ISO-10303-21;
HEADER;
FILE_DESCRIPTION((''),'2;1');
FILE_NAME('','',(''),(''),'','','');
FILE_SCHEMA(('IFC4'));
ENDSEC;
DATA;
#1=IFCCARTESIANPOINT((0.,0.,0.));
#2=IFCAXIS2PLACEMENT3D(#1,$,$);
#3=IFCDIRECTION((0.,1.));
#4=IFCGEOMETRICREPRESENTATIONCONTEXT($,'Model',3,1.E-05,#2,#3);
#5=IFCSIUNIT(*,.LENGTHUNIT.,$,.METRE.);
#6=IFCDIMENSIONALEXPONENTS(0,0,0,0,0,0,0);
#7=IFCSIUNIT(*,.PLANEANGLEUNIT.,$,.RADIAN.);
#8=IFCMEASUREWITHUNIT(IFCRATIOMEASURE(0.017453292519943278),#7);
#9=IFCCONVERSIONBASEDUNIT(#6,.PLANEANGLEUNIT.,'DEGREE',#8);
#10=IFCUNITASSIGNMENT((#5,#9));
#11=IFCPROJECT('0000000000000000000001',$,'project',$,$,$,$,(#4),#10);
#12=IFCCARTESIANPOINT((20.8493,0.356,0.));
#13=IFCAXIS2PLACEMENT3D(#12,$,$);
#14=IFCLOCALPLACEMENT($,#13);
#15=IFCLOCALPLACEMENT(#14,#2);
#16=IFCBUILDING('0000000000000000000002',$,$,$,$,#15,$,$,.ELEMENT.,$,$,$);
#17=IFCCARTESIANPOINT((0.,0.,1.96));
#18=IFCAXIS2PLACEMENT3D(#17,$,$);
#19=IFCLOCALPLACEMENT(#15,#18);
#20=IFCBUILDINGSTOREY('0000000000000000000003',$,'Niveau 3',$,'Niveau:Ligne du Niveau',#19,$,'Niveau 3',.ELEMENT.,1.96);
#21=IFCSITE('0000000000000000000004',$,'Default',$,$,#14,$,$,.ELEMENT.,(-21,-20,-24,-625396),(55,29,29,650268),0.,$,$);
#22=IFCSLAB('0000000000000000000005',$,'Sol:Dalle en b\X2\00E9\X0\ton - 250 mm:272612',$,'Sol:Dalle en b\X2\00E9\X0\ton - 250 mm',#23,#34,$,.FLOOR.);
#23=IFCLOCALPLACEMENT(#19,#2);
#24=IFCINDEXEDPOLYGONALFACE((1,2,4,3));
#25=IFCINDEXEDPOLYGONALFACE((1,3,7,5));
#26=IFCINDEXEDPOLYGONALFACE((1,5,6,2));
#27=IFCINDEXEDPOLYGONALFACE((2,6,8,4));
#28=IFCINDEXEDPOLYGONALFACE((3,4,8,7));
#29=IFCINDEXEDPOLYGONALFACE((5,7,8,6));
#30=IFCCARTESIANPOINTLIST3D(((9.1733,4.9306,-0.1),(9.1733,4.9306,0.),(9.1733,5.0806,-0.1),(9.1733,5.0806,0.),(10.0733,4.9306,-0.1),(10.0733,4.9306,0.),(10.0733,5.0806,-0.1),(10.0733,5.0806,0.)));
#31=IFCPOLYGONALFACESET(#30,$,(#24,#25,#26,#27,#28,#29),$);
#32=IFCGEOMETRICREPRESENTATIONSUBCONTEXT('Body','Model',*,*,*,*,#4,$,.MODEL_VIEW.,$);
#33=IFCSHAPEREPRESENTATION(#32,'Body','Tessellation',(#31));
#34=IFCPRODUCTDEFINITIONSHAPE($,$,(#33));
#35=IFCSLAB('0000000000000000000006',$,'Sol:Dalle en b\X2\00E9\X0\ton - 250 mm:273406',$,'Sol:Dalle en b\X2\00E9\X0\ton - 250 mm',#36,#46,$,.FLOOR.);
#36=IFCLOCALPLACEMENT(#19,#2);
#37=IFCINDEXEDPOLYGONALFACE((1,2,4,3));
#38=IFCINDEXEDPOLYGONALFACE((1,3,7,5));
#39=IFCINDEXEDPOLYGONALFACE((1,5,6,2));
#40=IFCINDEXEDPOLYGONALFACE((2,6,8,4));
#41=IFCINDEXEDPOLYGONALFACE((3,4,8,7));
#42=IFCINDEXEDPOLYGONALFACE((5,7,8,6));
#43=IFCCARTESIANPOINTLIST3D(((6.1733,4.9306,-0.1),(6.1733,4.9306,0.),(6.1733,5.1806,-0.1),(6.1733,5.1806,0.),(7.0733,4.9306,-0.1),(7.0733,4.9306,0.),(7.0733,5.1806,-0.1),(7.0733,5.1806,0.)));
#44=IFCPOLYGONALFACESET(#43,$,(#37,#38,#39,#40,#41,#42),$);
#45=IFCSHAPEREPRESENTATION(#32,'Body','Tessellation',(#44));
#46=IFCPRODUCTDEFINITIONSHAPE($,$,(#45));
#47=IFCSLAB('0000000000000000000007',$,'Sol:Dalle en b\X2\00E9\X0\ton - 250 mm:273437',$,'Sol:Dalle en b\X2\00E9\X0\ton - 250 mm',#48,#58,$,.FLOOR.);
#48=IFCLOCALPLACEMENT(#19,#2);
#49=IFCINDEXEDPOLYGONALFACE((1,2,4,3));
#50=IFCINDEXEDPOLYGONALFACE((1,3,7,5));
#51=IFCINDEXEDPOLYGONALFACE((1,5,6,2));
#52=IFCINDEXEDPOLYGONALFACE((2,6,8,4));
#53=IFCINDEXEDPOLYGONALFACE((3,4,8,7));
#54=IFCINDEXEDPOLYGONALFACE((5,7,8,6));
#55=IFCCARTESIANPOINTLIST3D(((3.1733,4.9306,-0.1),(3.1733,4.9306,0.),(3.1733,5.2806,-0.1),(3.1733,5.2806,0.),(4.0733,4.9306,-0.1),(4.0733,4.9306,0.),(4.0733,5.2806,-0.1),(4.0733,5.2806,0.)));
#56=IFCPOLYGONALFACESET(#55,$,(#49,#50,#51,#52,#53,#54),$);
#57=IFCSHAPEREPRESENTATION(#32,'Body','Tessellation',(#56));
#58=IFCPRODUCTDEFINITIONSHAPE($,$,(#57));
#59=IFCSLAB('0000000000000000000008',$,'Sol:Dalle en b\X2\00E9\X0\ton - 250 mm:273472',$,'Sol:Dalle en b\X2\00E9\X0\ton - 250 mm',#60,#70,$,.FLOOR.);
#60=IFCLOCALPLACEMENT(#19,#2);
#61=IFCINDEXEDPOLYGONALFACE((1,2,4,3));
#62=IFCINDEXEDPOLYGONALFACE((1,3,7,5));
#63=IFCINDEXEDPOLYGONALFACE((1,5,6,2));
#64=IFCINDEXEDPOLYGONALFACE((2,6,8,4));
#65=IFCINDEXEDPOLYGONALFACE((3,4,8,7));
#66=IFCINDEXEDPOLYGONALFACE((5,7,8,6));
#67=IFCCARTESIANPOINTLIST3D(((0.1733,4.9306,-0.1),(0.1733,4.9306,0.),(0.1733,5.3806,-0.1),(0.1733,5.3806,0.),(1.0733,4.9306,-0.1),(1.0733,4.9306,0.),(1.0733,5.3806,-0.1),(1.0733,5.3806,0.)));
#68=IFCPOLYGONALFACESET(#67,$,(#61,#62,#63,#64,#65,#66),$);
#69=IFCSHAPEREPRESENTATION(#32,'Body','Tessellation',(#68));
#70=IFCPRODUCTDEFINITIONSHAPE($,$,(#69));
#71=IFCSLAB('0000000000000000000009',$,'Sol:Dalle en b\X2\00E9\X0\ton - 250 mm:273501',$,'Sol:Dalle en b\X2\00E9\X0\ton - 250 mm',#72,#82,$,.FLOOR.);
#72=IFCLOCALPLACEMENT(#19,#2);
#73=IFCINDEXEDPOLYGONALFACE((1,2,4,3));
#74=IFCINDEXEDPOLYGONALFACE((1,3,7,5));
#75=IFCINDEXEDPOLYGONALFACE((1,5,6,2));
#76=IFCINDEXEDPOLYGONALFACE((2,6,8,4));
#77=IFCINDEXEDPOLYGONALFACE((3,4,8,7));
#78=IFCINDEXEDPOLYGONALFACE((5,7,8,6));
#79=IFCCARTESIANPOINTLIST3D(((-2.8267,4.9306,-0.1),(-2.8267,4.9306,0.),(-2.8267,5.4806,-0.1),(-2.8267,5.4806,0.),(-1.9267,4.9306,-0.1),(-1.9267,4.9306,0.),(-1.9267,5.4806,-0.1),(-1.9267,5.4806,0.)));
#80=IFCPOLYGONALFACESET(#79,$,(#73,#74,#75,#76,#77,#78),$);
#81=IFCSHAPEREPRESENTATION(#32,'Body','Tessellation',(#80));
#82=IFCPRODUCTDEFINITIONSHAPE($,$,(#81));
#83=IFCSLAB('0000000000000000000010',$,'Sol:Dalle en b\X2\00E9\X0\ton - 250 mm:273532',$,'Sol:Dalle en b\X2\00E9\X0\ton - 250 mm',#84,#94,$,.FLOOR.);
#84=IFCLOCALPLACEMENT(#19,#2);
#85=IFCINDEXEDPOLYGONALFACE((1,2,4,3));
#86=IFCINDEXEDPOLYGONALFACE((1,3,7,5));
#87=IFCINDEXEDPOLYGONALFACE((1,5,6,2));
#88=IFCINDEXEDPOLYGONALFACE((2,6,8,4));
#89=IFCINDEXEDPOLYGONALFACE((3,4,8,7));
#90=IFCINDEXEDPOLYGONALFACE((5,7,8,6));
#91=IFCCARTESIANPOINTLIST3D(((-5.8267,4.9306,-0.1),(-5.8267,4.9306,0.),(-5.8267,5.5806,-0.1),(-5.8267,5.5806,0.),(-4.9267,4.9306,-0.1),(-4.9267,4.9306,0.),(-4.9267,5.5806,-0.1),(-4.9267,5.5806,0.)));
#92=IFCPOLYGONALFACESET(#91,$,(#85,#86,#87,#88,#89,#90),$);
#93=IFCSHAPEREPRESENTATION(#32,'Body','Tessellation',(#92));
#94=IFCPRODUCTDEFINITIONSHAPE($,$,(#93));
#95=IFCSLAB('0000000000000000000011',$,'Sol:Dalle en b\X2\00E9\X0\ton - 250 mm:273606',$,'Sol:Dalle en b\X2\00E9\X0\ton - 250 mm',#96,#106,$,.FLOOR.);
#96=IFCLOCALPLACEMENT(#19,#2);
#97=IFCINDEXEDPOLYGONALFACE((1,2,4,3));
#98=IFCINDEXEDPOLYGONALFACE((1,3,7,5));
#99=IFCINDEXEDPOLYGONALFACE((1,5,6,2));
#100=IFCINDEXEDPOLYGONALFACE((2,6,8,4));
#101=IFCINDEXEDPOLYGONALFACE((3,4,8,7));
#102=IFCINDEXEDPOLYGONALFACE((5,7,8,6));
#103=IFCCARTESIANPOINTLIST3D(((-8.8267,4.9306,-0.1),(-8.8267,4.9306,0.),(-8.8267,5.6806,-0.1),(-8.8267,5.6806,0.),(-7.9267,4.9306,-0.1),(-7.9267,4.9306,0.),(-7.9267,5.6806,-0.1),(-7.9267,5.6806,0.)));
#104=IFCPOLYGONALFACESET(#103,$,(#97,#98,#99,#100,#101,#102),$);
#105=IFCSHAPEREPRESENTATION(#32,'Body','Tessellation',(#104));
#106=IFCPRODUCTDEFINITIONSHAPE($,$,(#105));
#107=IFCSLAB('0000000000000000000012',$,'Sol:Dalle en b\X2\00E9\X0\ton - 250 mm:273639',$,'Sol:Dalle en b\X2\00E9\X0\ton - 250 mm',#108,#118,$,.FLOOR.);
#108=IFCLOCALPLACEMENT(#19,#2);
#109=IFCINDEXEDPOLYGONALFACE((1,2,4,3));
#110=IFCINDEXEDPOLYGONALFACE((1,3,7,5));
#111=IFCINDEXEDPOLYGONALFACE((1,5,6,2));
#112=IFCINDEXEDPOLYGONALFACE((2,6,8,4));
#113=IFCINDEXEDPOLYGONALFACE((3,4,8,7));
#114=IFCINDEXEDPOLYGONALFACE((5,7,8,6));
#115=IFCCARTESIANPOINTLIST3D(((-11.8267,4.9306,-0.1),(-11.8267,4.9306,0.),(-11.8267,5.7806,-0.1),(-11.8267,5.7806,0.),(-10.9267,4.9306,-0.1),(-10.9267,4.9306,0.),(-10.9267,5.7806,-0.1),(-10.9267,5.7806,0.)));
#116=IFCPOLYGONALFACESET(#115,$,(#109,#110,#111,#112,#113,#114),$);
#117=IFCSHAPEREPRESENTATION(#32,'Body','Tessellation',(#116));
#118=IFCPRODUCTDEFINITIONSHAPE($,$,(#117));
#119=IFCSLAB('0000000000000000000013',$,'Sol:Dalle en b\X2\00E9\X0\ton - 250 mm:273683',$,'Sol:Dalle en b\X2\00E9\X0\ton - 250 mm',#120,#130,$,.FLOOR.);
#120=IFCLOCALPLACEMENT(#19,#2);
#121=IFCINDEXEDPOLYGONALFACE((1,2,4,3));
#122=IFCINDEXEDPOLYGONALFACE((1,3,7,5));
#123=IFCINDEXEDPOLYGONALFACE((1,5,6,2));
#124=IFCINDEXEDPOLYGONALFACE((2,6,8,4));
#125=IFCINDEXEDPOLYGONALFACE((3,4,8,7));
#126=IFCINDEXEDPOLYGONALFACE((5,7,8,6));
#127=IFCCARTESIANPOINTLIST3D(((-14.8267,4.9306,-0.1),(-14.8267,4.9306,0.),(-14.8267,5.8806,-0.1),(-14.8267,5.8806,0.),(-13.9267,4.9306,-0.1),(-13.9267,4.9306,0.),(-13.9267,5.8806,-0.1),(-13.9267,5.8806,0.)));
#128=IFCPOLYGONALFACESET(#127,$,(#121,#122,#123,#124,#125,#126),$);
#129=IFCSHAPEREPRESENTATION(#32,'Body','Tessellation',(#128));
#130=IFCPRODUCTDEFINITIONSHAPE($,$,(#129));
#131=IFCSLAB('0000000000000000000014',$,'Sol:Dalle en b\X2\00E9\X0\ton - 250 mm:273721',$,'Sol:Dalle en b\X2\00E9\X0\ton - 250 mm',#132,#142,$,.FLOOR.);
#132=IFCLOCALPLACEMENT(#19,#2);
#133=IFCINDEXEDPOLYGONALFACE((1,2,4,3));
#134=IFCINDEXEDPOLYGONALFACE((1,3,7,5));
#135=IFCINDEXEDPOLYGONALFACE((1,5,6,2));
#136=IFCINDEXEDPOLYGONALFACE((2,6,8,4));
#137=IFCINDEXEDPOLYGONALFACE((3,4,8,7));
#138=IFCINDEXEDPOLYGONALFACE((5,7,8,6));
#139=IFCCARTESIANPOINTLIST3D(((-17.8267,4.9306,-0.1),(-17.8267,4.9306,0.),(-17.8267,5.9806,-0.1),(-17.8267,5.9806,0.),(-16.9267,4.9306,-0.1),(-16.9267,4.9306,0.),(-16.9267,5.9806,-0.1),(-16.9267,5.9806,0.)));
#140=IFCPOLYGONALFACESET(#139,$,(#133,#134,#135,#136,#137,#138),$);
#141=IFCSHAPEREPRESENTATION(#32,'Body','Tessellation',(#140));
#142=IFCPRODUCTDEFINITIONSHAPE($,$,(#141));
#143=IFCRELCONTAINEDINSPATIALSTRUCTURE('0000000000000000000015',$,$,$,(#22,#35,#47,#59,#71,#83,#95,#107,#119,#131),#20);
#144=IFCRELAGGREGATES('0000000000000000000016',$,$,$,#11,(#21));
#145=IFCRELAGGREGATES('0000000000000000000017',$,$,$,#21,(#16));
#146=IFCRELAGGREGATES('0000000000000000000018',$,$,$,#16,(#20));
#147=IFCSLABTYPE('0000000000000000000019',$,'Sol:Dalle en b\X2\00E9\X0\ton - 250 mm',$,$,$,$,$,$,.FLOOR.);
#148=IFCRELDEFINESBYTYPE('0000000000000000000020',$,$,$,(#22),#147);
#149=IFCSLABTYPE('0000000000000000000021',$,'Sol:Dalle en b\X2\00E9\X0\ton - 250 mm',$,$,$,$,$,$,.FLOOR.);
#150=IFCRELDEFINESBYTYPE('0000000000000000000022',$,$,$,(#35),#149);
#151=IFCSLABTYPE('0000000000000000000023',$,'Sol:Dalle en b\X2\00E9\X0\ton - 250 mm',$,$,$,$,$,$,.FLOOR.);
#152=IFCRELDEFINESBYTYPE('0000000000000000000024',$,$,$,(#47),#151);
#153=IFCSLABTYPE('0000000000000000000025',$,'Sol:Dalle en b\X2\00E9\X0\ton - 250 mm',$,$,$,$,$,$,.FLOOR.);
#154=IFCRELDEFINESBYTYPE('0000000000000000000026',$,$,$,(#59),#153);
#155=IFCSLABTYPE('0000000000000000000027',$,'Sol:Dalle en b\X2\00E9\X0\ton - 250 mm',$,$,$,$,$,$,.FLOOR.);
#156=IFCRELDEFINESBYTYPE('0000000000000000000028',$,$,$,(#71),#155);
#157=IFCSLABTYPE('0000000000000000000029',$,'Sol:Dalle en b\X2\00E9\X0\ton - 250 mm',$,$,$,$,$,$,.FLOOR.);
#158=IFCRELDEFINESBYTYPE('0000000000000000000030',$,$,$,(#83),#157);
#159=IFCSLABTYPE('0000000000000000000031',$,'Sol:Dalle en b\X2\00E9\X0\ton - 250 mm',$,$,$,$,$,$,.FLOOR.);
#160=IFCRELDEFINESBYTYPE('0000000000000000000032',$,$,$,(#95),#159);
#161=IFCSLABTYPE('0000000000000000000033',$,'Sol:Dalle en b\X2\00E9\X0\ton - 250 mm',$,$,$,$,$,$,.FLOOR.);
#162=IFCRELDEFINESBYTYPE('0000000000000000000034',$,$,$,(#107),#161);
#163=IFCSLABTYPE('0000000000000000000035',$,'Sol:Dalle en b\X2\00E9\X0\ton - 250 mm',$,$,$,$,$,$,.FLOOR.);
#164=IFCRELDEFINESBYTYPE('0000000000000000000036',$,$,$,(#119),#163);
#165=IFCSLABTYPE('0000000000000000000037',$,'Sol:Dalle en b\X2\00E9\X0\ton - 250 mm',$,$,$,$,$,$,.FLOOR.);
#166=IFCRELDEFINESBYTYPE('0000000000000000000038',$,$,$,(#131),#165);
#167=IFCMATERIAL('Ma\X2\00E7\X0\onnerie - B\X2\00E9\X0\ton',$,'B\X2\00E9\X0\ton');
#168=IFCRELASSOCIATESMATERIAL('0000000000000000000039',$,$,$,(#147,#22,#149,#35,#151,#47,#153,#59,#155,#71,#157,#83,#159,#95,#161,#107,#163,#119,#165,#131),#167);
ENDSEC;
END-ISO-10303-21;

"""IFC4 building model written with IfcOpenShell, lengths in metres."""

from ifc_helpers import new_model, entity, si_unit, converted_unit, direction, frame, origin, place, context, subcontext, project, spatial, indexed_curve, outline, extrude, material, type_object, element, save


model = new_model("IFC4")

# Units and contexts
model_context = context("Model", 3, precision=1e-05, world=origin(), true_north=direction((0.0, 1.0)))
body_context = subcontext(model_context, "Body", "Model", "MODEL_VIEW")
ifc_project = project(units=[si_unit("LENGTHUNIT", "METRE"), converted_unit("PLANEANGLEUNIT", "DEGREE", entity("IfcRatioMeasure", 0.017453292519943278), si_unit("PLANEANGLEUNIT", "RADIAN"), dimensions=[0, 0, 0, 0, 0, 0, 0])], contexts=[model_context])

# Site, building, storey
site_placement = place(None, frame((20.8493, 0.356, 0.0)))
site = spatial("IfcSite", under=ifc_project, at=site_placement, Name="Default", CompositionType="ELEMENT", RefLatitude=(-21, -20, -24, -625396), RefLongitude=(55, 29, 29, 650268), RefElevation=0.0)
building_placement = place(site_placement, origin())
building = spatial("IfcBuilding", under=site, at=building_placement, CompositionType="ELEMENT")
storey_placement = place(building_placement, frame((0.0, 0.0, 1.96)))
storey = spatial("IfcBuildingStorey", under=building, at=storey_placement, Name="Niveau 3", ObjectType="Niveau:Ligne du Niveau", LongName="Niveau 3", CompositionType="ELEMENT", Elevation=1.96)

# Slabs
ifc_material = material(Name="Maçonnerie - Béton", Category="Béton")
slab_type_1 = type_object("IfcSlabType", Name="Sol:Dalle en béton - 250 mm", PredefinedType="FLOOR", material=ifc_material)
slab_1_placement = place(storey_placement, origin())
element("IfcSlab", 1, at=slab_1_placement, inside=storey, type_object=slab_type_1, material=ifc_material, Name="Sol:Dalle en béton - 250 mm:272612", ObjectType="Sol:Dalle en béton - 250 mm", PredefinedType="FLOOR", context=body_context, shape_type="SweptSolid", body=[
    extrude(outline(indexed_curve([(-0.075, -0.45), (0.075, -0.45), (0.075, 0.45), (-0.075, 0.45), (-0.075, -0.45)], self_intersect=False)), frame((9.6233, 5.0056, 0.0), z_axis=(0.0, 0.0, -1.0), x_axis=(0.0, 1.0, 0.0)), (0.0, 0.0, 1.0), 0.1),
])
slab_type_2 = type_object("IfcSlabType", Name="Sol:Dalle en béton - 250 mm", PredefinedType="FLOOR", material=ifc_material)
slab_2_placement = place(storey_placement, origin())
element("IfcSlab", 2, at=slab_2_placement, inside=storey, type_object=slab_type_2, material=ifc_material, Name="Sol:Dalle en béton - 250 mm:273406", ObjectType="Sol:Dalle en béton - 250 mm", PredefinedType="FLOOR", context=body_context, shape_type="SweptSolid", body=[
    extrude(outline(indexed_curve([(-0.125, -0.45), (0.125, -0.45), (0.125, 0.45), (-0.125, 0.45), (-0.125, -0.45)], self_intersect=False)), frame((6.6233, 5.0556, 0.0), z_axis=(0.0, 0.0, -1.0), x_axis=(0.0, 1.0, 0.0)), (0.0, 0.0, 1.0), 0.1),
])
slab_type_3 = type_object("IfcSlabType", Name="Sol:Dalle en béton - 250 mm", PredefinedType="FLOOR", material=ifc_material)
slab_3_placement = place(storey_placement, origin())
element("IfcSlab", 3, at=slab_3_placement, inside=storey, type_object=slab_type_3, material=ifc_material, Name="Sol:Dalle en béton - 250 mm:273437", ObjectType="Sol:Dalle en béton - 250 mm", PredefinedType="FLOOR", context=body_context, shape_type="SweptSolid", body=[
    extrude(outline(indexed_curve([(-0.175, -0.45), (0.175, -0.45), (0.175, 0.45), (-0.175, 0.45), (-0.175, -0.45)], self_intersect=False)), frame((3.6233, 5.1056, 0.0), z_axis=(0.0, 0.0, -1.0), x_axis=(0.0, 1.0, 0.0)), (0.0, 0.0, 1.0), 0.1),
])
slab_type_4 = type_object("IfcSlabType", Name="Sol:Dalle en béton - 250 mm", PredefinedType="FLOOR", material=ifc_material)
slab_4_placement = place(storey_placement, origin())
element("IfcSlab", 4, at=slab_4_placement, inside=storey, type_object=slab_type_4, material=ifc_material, Name="Sol:Dalle en béton - 250 mm:273472", ObjectType="Sol:Dalle en béton - 250 mm", PredefinedType="FLOOR", context=body_context, shape_type="SweptSolid", body=[
    extrude(outline(indexed_curve([(-0.225, -0.45), (0.225, -0.45), (0.225, 0.45), (-0.225, 0.45), (-0.225, -0.45)], self_intersect=False)), frame((0.6233, 5.1556, 0.0), z_axis=(0.0, 0.0, -1.0), x_axis=(0.0, 1.0, 0.0)), (0.0, 0.0, 1.0), 0.1),
])
slab_type_5 = type_object("IfcSlabType", Name="Sol:Dalle en béton - 250 mm", PredefinedType="FLOOR", material=ifc_material)
slab_5_placement = place(storey_placement, origin())
element("IfcSlab", 5, at=slab_5_placement, inside=storey, type_object=slab_type_5, material=ifc_material, Name="Sol:Dalle en béton - 250 mm:273501", ObjectType="Sol:Dalle en béton - 250 mm", PredefinedType="FLOOR", context=body_context, shape_type="SweptSolid", body=[
    extrude(outline(indexed_curve([(-0.275, -0.45), (0.275, -0.45), (0.275, 0.45), (-0.275, 0.45), (-0.275, -0.45)], self_intersect=False)), frame((-2.3767, 5.2056, 0.0), z_axis=(0.0, 0.0, -1.0), x_axis=(0.0, 1.0, 0.0)), (0.0, 0.0, 1.0), 0.1),
])
slab_type_6 = type_object("IfcSlabType", Name="Sol:Dalle en béton - 250 mm", PredefinedType="FLOOR", material=ifc_material)
slab_6_placement = place(storey_placement, origin())
element("IfcSlab", 6, at=slab_6_placement, inside=storey, type_object=slab_type_6, material=ifc_material, Name="Sol:Dalle en béton - 250 mm:273532", ObjectType="Sol:Dalle en béton - 250 mm", PredefinedType="FLOOR", context=body_context, shape_type="SweptSolid", body=[
    extrude(outline(indexed_curve([(-0.325, -0.45), (0.325, -0.45), (0.325, 0.45), (-0.325, 0.45), (-0.325, -0.45)], self_intersect=False)), frame((-5.3767, 5.2556, 0.0), z_axis=(0.0, 0.0, -1.0), x_axis=(0.0, 1.0, 0.0)), (0.0, 0.0, 1.0), 0.1),
])
slab_type_7 = type_object("IfcSlabType", Name="Sol:Dalle en béton - 250 mm", PredefinedType="FLOOR", material=ifc_material)
slab_7_placement = place(storey_placement, origin())
element("IfcSlab", 7, at=slab_7_placement, inside=storey, type_object=slab_type_7, material=ifc_material, Name="Sol:Dalle en béton - 250 mm:273606", ObjectType="Sol:Dalle en béton - 250 mm", PredefinedType="FLOOR", context=body_context, shape_type="SweptSolid", body=[
    extrude(outline(indexed_curve([(-0.375, -0.45), (0.375, -0.45), (0.375, 0.45), (-0.375, 0.45), (-0.375, -0.45)], self_intersect=False)), frame((-8.3767, 5.3056, 0.0), z_axis=(0.0, 0.0, -1.0), x_axis=(0.0, 1.0, 0.0)), (0.0, 0.0, 1.0), 0.1),
])
slab_type_8 = type_object("IfcSlabType", Name="Sol:Dalle en béton - 250 mm", PredefinedType="FLOOR", material=ifc_material)
slab_8_placement = place(storey_placement, origin())
element("IfcSlab", 8, at=slab_8_placement, inside=storey, type_object=slab_type_8, material=ifc_material, Name="Sol:Dalle en béton - 250 mm:273639", ObjectType="Sol:Dalle en béton - 250 mm", PredefinedType="FLOOR", context=body_context, shape_type="SweptSolid", body=[
    extrude(outline(indexed_curve([(-0.425, -0.45), (0.425, -0.45), (0.425, 0.45), (-0.425, 0.45), (-0.425, -0.45)], self_intersect=False)), frame((-11.3767, 5.3556, 0.0), z_axis=(0.0, 0.0, -1.0), x_axis=(0.0, 1.0, 0.0)), (0.0, 0.0, 1.0), 0.1),
])
slab_type_9 = type_object("IfcSlabType", Name="Sol:Dalle en béton - 250 mm", PredefinedType="FLOOR", material=ifc_material)
slab_9_placement = place(storey_placement, origin())
element("IfcSlab", 9, at=slab_9_placement, inside=storey, type_object=slab_type_9, material=ifc_material, Name="Sol:Dalle en béton - 250 mm:273683", ObjectType="Sol:Dalle en béton - 250 mm", PredefinedType="FLOOR", context=body_context, shape_type="SweptSolid", body=[
    extrude(outline(indexed_curve([(-0.475, -0.45), (0.475, -0.45), (0.475, 0.45), (-0.475, 0.45), (-0.475, -0.45)], self_intersect=False)), frame((-14.3767, 5.4056, 0.0), z_axis=(0.0, 0.0, -1.0), x_axis=(0.0, 1.0, 0.0)), (0.0, 0.0, 1.0), 0.1),
])
slab_type_10 = type_object("IfcSlabType", Name="Sol:Dalle en béton - 250 mm", PredefinedType="FLOOR", material=ifc_material)
slab_10_placement = place(storey_placement, origin())
element("IfcSlab", 10, at=slab_10_placement, inside=storey, type_object=slab_type_10, material=ifc_material, Name="Sol:Dalle en béton - 250 mm:273721", ObjectType="Sol:Dalle en béton - 250 mm", PredefinedType="FLOOR", context=body_context, shape_type="SweptSolid", body=[
    extrude(outline(indexed_curve([(-0.525, -0.45), (0.525, -0.45), (0.525, 0.45), (-0.525, 0.45), (-0.525, -0.45)], self_intersect=False)), frame((-17.3767, 5.4556, 0.0), z_axis=(0.0, 0.0, -1.0), x_axis=(0.0, 1.0, 0.0)), (0.0, 0.0, 1.0), 0.1),
])

save(model, "model.ifc")
